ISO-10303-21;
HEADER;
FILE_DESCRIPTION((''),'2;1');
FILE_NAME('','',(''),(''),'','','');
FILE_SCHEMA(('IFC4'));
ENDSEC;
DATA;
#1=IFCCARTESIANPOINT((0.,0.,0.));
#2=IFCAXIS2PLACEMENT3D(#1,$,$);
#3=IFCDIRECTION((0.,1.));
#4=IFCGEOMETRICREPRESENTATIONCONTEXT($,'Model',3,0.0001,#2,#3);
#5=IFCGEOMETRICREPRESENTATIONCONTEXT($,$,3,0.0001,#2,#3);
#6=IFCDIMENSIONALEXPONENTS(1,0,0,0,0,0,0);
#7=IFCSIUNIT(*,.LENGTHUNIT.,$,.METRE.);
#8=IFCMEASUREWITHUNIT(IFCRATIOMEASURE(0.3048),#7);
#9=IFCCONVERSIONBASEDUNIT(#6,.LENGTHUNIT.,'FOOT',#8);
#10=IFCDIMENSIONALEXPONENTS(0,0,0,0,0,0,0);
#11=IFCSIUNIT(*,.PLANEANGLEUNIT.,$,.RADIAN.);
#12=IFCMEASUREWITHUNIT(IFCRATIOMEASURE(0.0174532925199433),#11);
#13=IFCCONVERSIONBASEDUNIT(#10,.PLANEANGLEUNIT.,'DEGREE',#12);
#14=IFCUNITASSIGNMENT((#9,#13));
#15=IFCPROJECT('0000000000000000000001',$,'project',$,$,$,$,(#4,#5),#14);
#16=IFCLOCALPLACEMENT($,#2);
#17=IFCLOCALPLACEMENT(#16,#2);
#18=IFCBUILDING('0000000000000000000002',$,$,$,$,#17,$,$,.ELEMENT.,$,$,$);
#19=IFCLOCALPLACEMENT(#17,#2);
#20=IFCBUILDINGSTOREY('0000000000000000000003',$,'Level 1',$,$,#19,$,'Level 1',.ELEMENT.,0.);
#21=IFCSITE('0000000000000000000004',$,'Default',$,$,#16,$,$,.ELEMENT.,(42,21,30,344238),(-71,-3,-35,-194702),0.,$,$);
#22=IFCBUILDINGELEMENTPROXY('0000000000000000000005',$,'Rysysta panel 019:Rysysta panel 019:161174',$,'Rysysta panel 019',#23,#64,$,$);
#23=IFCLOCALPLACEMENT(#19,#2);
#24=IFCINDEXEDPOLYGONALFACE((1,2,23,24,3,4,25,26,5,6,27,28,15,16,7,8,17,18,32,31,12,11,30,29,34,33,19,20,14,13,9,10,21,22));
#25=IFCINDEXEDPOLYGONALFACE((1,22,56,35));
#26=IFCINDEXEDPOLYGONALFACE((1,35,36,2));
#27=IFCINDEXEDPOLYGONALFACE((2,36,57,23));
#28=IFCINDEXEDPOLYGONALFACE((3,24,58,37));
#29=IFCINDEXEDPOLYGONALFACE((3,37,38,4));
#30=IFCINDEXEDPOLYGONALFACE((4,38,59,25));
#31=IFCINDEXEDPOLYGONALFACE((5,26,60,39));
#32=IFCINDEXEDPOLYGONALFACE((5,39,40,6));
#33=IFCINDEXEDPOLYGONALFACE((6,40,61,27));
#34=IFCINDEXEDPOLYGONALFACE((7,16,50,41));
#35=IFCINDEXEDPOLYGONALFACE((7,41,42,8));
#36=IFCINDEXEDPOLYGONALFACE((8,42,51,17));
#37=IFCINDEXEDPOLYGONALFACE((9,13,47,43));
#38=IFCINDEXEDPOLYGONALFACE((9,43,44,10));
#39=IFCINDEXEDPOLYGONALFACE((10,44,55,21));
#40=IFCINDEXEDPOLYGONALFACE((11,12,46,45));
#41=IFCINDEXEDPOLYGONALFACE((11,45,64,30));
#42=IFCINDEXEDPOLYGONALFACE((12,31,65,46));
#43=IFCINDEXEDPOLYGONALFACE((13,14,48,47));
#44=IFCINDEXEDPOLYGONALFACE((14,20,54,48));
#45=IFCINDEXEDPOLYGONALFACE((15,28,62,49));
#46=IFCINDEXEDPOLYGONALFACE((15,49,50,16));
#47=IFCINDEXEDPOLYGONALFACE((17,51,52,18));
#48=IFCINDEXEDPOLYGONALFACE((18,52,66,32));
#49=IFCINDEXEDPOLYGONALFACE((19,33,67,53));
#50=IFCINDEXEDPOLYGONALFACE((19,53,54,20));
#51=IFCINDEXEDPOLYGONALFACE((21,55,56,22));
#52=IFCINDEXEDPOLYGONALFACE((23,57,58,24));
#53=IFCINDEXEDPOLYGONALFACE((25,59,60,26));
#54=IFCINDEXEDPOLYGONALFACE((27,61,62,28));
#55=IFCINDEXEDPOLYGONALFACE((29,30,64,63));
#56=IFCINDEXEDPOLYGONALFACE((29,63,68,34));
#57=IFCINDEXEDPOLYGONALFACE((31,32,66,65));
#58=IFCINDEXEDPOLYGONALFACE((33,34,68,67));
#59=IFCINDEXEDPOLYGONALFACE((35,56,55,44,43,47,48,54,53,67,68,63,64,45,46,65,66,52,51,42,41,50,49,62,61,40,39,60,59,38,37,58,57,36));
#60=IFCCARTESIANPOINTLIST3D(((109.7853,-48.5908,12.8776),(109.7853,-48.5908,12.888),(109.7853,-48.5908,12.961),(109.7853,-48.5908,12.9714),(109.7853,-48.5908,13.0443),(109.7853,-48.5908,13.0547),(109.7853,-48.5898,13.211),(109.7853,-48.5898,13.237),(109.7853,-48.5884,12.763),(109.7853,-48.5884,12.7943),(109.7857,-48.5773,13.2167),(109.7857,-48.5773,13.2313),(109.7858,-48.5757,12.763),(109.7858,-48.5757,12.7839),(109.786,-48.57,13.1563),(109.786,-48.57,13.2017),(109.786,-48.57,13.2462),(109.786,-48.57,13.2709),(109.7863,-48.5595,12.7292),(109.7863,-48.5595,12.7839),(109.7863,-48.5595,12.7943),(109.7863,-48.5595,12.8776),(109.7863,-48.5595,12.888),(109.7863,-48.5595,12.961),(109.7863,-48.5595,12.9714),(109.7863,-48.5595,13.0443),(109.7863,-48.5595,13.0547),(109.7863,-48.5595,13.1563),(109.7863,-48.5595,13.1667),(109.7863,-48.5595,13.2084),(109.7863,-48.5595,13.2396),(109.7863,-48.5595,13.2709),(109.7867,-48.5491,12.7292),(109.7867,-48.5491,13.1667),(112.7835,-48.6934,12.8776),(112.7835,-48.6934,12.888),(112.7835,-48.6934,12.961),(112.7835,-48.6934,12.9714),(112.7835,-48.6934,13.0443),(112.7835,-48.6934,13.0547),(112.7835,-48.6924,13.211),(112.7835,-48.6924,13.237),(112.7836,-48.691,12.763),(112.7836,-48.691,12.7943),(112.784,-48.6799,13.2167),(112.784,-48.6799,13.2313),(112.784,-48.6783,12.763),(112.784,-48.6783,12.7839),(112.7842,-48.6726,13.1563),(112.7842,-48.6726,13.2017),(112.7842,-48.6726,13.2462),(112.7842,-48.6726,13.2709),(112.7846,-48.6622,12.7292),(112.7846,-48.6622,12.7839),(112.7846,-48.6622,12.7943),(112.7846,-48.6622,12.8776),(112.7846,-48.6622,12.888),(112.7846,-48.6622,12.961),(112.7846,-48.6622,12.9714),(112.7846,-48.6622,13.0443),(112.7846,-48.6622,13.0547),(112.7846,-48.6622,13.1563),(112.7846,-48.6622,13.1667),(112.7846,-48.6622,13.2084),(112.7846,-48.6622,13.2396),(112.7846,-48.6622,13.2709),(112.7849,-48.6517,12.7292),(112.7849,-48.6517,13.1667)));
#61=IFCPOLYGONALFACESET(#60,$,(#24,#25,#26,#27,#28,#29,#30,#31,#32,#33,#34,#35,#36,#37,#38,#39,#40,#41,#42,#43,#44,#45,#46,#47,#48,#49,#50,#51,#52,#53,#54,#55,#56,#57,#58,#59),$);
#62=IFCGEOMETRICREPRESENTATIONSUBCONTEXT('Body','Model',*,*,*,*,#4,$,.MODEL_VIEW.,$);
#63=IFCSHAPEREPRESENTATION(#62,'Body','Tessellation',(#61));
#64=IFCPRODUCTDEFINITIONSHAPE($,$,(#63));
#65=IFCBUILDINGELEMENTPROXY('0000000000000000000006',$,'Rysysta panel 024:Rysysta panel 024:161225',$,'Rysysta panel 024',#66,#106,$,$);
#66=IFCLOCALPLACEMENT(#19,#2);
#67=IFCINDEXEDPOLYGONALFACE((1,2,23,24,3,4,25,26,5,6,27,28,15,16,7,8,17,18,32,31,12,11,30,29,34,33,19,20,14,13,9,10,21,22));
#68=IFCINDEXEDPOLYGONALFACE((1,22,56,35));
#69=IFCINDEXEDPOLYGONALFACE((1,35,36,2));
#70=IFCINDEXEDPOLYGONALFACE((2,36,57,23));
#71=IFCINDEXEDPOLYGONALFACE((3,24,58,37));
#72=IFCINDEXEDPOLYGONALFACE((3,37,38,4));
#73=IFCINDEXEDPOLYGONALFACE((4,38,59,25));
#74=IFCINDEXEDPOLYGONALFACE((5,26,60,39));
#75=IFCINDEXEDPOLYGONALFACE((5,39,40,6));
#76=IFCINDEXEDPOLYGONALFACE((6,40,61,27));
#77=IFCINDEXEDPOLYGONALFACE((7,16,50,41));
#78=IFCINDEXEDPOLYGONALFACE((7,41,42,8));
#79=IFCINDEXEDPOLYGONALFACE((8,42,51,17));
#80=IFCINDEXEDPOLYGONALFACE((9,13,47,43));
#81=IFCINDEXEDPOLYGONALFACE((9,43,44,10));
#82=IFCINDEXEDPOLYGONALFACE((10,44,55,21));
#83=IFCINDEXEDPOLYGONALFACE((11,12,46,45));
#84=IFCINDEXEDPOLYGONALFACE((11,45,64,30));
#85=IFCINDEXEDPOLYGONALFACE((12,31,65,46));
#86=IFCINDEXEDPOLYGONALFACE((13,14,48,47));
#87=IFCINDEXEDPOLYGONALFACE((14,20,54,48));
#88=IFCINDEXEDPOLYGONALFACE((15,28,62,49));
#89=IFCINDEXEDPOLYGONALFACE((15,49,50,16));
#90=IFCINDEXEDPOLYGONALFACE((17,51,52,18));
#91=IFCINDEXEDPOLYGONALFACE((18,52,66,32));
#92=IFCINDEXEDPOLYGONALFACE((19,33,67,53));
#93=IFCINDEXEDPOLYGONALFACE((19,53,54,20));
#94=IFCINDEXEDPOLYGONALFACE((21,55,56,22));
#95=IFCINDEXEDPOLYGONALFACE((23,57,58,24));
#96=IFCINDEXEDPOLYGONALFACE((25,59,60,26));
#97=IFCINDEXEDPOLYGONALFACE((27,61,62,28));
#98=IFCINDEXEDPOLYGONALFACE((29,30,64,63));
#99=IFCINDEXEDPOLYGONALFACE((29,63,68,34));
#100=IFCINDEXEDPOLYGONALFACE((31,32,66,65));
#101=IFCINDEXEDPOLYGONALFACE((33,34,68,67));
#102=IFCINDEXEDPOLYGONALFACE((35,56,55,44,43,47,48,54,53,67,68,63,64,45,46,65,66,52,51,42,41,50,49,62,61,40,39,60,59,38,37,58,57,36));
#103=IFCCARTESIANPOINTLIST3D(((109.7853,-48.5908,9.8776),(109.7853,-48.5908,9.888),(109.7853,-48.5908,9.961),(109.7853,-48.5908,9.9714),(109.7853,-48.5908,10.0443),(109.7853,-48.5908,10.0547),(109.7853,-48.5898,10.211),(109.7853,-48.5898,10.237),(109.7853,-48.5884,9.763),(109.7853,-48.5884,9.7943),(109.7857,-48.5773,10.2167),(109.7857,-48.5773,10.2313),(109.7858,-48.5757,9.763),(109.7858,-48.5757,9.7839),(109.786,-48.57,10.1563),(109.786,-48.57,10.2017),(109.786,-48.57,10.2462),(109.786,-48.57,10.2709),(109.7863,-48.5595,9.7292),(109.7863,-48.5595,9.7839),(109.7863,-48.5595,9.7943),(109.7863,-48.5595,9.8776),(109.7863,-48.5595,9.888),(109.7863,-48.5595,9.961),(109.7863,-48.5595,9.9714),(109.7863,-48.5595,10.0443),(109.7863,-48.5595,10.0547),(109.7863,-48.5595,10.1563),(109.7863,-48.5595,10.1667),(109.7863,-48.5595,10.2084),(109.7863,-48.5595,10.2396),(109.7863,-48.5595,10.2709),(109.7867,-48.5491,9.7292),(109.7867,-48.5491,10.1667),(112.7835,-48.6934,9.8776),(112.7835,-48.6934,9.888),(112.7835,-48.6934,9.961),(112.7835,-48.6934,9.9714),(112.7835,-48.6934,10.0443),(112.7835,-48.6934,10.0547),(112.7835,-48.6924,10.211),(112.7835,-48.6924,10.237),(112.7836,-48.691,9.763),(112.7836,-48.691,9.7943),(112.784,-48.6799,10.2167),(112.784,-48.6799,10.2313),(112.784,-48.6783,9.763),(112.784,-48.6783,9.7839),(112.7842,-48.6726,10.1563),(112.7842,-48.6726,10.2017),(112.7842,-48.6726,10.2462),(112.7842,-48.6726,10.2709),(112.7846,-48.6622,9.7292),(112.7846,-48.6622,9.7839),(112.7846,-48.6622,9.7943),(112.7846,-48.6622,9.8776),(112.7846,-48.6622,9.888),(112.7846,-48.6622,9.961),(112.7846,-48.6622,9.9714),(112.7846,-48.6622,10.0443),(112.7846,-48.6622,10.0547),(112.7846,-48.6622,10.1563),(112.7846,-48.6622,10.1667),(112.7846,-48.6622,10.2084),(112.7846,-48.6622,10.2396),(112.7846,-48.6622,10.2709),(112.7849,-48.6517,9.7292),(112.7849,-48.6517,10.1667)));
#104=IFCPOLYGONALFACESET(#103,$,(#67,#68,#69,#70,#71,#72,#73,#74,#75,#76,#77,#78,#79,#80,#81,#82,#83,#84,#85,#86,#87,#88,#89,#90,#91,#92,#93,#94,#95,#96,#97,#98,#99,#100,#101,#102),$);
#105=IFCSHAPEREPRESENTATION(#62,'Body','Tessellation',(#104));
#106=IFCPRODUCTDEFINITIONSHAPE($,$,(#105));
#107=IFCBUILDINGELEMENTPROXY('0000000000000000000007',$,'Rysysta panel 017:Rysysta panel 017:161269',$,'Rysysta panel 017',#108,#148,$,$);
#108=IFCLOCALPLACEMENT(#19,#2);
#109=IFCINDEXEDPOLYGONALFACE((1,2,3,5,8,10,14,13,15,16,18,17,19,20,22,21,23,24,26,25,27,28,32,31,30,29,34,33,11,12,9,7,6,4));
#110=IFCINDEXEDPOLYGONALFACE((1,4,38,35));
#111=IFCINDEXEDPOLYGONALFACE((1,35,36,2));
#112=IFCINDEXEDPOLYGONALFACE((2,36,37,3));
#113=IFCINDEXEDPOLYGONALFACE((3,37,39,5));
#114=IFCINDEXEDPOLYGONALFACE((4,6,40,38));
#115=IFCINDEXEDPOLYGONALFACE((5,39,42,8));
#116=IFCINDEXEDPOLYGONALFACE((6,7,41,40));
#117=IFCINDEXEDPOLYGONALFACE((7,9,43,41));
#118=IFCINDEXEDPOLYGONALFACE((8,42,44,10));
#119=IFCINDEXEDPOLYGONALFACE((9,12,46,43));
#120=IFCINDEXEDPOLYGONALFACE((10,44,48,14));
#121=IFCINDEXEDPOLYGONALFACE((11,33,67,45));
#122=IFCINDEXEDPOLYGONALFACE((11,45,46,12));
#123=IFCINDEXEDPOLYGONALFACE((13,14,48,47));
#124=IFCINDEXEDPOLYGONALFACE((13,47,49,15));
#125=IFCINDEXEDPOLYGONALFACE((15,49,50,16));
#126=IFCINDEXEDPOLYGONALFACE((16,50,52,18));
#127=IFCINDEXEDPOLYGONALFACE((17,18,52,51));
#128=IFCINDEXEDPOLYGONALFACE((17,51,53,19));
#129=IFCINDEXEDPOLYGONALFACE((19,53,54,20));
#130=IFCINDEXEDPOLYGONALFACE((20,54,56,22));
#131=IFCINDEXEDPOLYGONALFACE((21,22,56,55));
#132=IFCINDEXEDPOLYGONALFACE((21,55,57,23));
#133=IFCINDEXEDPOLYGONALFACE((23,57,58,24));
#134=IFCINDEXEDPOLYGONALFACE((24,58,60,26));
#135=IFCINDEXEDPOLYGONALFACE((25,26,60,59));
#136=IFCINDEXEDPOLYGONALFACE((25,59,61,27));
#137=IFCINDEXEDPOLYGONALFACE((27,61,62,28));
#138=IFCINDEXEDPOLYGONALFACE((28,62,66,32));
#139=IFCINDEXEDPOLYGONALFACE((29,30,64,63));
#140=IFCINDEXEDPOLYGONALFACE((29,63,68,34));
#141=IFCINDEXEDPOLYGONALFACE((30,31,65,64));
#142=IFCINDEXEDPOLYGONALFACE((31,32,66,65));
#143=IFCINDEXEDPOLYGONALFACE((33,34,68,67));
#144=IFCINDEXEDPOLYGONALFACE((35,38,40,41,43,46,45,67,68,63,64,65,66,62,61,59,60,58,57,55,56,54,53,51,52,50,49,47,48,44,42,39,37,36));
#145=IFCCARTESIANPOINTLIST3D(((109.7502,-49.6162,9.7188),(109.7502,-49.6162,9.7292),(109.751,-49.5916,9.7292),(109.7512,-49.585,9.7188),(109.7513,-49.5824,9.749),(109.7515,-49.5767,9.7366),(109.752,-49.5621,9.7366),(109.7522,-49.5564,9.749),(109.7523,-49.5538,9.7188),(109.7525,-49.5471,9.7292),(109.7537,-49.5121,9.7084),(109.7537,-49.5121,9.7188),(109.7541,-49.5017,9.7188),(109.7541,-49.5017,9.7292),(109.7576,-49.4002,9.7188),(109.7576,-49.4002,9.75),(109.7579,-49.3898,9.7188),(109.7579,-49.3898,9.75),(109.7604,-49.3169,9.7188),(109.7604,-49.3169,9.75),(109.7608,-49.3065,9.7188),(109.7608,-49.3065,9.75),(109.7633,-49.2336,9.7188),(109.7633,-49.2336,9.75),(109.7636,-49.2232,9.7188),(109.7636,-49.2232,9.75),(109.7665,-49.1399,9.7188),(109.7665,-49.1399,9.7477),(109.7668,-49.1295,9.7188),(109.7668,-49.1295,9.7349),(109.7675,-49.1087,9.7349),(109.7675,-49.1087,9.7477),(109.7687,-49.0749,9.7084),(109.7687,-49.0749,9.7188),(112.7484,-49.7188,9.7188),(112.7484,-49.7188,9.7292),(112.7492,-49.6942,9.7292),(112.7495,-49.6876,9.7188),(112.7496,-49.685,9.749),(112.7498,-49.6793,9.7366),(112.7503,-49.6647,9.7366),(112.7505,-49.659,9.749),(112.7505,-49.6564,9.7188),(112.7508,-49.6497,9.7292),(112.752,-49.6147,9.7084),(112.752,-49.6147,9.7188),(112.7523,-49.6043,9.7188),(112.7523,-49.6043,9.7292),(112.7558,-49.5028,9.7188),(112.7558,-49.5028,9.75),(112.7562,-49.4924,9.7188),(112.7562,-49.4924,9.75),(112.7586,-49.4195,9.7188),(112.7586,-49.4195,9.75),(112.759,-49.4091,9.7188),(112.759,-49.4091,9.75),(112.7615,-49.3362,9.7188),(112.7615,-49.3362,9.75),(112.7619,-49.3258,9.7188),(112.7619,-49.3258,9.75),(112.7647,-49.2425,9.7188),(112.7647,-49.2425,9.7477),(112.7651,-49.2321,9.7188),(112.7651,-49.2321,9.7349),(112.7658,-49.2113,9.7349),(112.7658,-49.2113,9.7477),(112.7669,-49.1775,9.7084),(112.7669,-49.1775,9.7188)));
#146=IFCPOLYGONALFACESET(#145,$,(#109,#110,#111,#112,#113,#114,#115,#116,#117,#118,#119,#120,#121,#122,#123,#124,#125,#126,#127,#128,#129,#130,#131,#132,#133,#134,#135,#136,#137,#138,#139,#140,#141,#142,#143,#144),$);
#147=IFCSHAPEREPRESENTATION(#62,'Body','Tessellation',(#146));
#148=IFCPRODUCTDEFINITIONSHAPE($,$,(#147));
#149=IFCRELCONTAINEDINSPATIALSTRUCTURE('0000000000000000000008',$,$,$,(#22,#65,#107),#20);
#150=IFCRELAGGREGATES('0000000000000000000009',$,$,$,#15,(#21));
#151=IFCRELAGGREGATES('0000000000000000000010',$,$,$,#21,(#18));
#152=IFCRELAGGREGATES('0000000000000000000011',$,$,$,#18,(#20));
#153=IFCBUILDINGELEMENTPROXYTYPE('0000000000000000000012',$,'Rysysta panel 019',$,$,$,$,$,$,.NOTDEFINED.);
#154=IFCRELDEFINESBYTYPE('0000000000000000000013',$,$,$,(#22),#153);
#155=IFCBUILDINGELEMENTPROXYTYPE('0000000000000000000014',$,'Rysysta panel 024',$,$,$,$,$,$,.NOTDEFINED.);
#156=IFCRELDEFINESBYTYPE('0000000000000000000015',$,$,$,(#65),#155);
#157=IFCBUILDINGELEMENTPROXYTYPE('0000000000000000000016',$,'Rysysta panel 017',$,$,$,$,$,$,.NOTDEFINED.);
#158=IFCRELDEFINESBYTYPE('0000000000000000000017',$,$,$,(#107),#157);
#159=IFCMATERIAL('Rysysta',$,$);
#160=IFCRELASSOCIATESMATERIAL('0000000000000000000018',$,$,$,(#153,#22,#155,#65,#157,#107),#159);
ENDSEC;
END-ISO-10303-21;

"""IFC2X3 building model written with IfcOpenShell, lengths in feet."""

from ifc_helpers import new_model, entity, si_unit, converted_unit, direction, frame, origin, place, context, subcontext, project, spatial, polyline, outline, extrude, source, transform, mapped, material, type_object, type_shapes, element, save


model = new_model("IFC2X3")

# Units and contexts
model_context = context("Model", 3, precision=0.0001, world=origin(), true_north=direction((0.0, 1.0)))
context_of_model = context(None, 3, precision=0.0001, world=origin(), true_north=direction((0.0, 1.0)))
body_context = subcontext(model_context, "Body", "Model", "MODEL_VIEW")
ifc_project = project(units=[converted_unit("LENGTHUNIT", "FOOT", entity("IfcRatioMeasure", 0.3048), si_unit("LENGTHUNIT", "METRE"), dimensions=[1, 0, 0, 0, 0, 0, 0]), converted_unit("PLANEANGLEUNIT", "DEGREE", entity("IfcRatioMeasure", 0.0174532925199433), si_unit("PLANEANGLEUNIT", "RADIAN"), dimensions=[0, 0, 0, 0, 0, 0, 0])], contexts=[model_context, context_of_model])

# Site, building, storey
site_placement = place(None, origin())
site = spatial("IfcSite", under=ifc_project, at=site_placement, Name="Default", CompositionType="ELEMENT", RefLatitude=(42, 21, 30, 344238), RefLongitude=(-71, -3, -35, -194702), RefElevation=0.0)
building_placement = place(site_placement, origin())
building = spatial("IfcBuilding", under=site, at=building_placement, CompositionType="ELEMENT")
storey_placement = place(building_placement, origin())
storey = spatial("IfcBuildingStorey", under=building, at=storey_placement, Name="Level 1", LongName="Level 1", CompositionType="ELEMENT", Elevation=0.0)

# Building element proxies
ifc_material_1 = material(Name="Rysysta")
building_element_proxy_type_1 = type_object("IfcBuildingElementProxyType", Name="Rysysta panel 019", PredefinedType="NOTDEFINED", material=ifc_material_1)
shared_shape_1 = source(origin(), body_context, "Body", "SweptSolid", [
    extrude(outline(polyline([(-0.022, 0.1457), (-0.022, -0.2918), (-0.0116, -0.2918), (-0.0116, -0.2371), (0.0045, -0.2371), (0.0045, -0.258), (0.0173, -0.258), (0.0173, -0.2267), (-0.0116, -0.2267), (-0.0116, -0.1434), (0.0196, -0.1434), (0.0196, -0.133), (-0.0116, -0.133), (-0.0116, -0.06), (0.0196, -0.06), (0.0196, -0.0496), (-0.0116, -0.0496), (-0.0116, 0.0233), (0.0196, 0.0233), (0.0196, 0.0337), (-0.0116, 0.0337), (-0.0116, 0.1353), (-0.0012, 0.1353), (-0.0012, 0.1807), (0.0186, 0.1899), (0.0186, 0.216), (-0.0012, 0.2252), (-0.0012, 0.2498), (-0.0116, 0.2498), (-0.0116, 0.2186), (0.0062, 0.2103), (0.0062, 0.1956), (-0.0116, 0.1873), (-0.0116, 0.1457), (-0.022, 0.1457)])), frame((109.7859, -48.5711, 13.021), z_axis=(-0.999415, 0.034202, 0.0), x_axis=(-0.034202, -0.999415, 0.0)), (0.0, 0.0, -1.0), 3.0),
])
type_shapes(building_element_proxy_type_1, [shared_shape_1])
proxy_1_placement = place(storey_placement, origin())
element("IfcBuildingElementProxy", 1, at=proxy_1_placement, inside=storey, type_object=building_element_proxy_type_1, material=ifc_material_1, Name="Rysysta panel 019:Rysysta panel 019:161174", ObjectType="Rysysta panel 019", context=body_context, shape_type="MappedRepresentation", body=[
    mapped(shared_shape_1, transform((0.0, 0.0, 0.0), scale=1.0)),
])
building_element_proxy_type_2 = type_object("IfcBuildingElementProxyType", Name="Rysysta panel 024", PredefinedType="NOTDEFINED", material=ifc_material_1)
shared_shape_2 = source(origin(), body_context, "Body", "SweptSolid", [
    extrude(outline(polyline([(-0.022, 0.1457), (-0.022, -0.2918), (-0.0116, -0.2918), (-0.0116, -0.2371), (0.0045, -0.2371), (0.0045, -0.258), (0.0173, -0.258), (0.0173, -0.2267), (-0.0116, -0.2267), (-0.0116, -0.1434), (0.0196, -0.1434), (0.0196, -0.133), (-0.0116, -0.133), (-0.0116, -0.06), (0.0196, -0.06), (0.0196, -0.0496), (-0.0116, -0.0496), (-0.0116, 0.0233), (0.0196, 0.0233), (0.0196, 0.0337), (-0.0116, 0.0337), (-0.0116, 0.1353), (-0.0012, 0.1353), (-0.0012, 0.1807), (0.0186, 0.1899), (0.0186, 0.216), (-0.0012, 0.2252), (-0.0012, 0.2498), (-0.0116, 0.2498), (-0.0116, 0.2186), (0.0062, 0.2103), (0.0062, 0.1956), (-0.0116, 0.1873), (-0.0116, 0.1457), (-0.022, 0.1457)])), frame((109.7859, -48.5711, 10.021), z_axis=(-0.999415, 0.034202, 0.0), x_axis=(-0.034202, -0.999415, 0.0)), (0.0, 0.0, -1.0), 3.0),
])
type_shapes(building_element_proxy_type_2, [shared_shape_2])
proxy_2_placement = place(storey_placement, origin())
element("IfcBuildingElementProxy", 2, at=proxy_2_placement, inside=storey, type_object=building_element_proxy_type_2, material=ifc_material_1, Name="Rysysta panel 024:Rysysta panel 024:161225", ObjectType="Rysysta panel 024", context=body_context, shape_type="MappedRepresentation", body=[
    mapped(shared_shape_2, transform((0.0, 0.0, 0.0), scale=1.0)),
])
building_element_proxy_type_3 = type_object("IfcBuildingElementProxyType", Name="Rysysta panel 017", PredefinedType="NOTDEFINED", material=ifc_material_1)
shared_shape_3 = source(origin(), body_context, "Body", "SweptSolid", [
    extrude(outline(polyline([(-0.2918, -0.0116), (-0.2918, -0.022), (0.1457, -0.022), (0.1457, -0.0116), (0.1873, -0.0116), (0.1956, 0.0062), (0.2103, 0.0062), (0.2186, -0.0116), (0.2498, -0.0116), (0.2498, -0.0012), (0.2252, -0.0012), (0.216, 0.0186), (0.1899, 0.0186), (0.1807, -0.0012), (0.1353, -0.0012), (0.1353, -0.0116), (0.0337, -0.0116), (0.0337, 0.0196), (0.0233, 0.0196), (0.0233, -0.0116), (-0.0496, -0.0116), (-0.0496, 0.0196), (-0.06, 0.0196), (-0.06, -0.0116), (-0.133, -0.0116), (-0.133, 0.0196), (-0.1434, 0.0196), (-0.1434, -0.0116), (-0.2267, -0.0116), (-0.2267, 0.0173), (-0.258, 0.0173), (-0.258, 0.0045), (-0.2371, 0.0045), (-0.2371, -0.0116), (-0.2918, -0.0116)])), frame((109.7587, -49.3665, 9.7304), z_axis=(-0.999415, 0.034202, 0.0), x_axis=(-0.034202, -0.999415, 0.0)), (0.0, 0.0, -1.0), 3.0),
])
type_shapes(building_element_proxy_type_3, [shared_shape_3])
proxy_3_placement = place(storey_placement, origin())
element("IfcBuildingElementProxy", 3, at=proxy_3_placement, inside=storey, type_object=building_element_proxy_type_3, material=ifc_material_1, Name="Rysysta panel 017:Rysysta panel 017:161269", ObjectType="Rysysta panel 017", context=body_context, shape_type="MappedRepresentation", body=[
    mapped(shared_shape_3, transform((0.0, 0.0, 0.0), scale=1.0)),
])

save(model, "model.ifc")
